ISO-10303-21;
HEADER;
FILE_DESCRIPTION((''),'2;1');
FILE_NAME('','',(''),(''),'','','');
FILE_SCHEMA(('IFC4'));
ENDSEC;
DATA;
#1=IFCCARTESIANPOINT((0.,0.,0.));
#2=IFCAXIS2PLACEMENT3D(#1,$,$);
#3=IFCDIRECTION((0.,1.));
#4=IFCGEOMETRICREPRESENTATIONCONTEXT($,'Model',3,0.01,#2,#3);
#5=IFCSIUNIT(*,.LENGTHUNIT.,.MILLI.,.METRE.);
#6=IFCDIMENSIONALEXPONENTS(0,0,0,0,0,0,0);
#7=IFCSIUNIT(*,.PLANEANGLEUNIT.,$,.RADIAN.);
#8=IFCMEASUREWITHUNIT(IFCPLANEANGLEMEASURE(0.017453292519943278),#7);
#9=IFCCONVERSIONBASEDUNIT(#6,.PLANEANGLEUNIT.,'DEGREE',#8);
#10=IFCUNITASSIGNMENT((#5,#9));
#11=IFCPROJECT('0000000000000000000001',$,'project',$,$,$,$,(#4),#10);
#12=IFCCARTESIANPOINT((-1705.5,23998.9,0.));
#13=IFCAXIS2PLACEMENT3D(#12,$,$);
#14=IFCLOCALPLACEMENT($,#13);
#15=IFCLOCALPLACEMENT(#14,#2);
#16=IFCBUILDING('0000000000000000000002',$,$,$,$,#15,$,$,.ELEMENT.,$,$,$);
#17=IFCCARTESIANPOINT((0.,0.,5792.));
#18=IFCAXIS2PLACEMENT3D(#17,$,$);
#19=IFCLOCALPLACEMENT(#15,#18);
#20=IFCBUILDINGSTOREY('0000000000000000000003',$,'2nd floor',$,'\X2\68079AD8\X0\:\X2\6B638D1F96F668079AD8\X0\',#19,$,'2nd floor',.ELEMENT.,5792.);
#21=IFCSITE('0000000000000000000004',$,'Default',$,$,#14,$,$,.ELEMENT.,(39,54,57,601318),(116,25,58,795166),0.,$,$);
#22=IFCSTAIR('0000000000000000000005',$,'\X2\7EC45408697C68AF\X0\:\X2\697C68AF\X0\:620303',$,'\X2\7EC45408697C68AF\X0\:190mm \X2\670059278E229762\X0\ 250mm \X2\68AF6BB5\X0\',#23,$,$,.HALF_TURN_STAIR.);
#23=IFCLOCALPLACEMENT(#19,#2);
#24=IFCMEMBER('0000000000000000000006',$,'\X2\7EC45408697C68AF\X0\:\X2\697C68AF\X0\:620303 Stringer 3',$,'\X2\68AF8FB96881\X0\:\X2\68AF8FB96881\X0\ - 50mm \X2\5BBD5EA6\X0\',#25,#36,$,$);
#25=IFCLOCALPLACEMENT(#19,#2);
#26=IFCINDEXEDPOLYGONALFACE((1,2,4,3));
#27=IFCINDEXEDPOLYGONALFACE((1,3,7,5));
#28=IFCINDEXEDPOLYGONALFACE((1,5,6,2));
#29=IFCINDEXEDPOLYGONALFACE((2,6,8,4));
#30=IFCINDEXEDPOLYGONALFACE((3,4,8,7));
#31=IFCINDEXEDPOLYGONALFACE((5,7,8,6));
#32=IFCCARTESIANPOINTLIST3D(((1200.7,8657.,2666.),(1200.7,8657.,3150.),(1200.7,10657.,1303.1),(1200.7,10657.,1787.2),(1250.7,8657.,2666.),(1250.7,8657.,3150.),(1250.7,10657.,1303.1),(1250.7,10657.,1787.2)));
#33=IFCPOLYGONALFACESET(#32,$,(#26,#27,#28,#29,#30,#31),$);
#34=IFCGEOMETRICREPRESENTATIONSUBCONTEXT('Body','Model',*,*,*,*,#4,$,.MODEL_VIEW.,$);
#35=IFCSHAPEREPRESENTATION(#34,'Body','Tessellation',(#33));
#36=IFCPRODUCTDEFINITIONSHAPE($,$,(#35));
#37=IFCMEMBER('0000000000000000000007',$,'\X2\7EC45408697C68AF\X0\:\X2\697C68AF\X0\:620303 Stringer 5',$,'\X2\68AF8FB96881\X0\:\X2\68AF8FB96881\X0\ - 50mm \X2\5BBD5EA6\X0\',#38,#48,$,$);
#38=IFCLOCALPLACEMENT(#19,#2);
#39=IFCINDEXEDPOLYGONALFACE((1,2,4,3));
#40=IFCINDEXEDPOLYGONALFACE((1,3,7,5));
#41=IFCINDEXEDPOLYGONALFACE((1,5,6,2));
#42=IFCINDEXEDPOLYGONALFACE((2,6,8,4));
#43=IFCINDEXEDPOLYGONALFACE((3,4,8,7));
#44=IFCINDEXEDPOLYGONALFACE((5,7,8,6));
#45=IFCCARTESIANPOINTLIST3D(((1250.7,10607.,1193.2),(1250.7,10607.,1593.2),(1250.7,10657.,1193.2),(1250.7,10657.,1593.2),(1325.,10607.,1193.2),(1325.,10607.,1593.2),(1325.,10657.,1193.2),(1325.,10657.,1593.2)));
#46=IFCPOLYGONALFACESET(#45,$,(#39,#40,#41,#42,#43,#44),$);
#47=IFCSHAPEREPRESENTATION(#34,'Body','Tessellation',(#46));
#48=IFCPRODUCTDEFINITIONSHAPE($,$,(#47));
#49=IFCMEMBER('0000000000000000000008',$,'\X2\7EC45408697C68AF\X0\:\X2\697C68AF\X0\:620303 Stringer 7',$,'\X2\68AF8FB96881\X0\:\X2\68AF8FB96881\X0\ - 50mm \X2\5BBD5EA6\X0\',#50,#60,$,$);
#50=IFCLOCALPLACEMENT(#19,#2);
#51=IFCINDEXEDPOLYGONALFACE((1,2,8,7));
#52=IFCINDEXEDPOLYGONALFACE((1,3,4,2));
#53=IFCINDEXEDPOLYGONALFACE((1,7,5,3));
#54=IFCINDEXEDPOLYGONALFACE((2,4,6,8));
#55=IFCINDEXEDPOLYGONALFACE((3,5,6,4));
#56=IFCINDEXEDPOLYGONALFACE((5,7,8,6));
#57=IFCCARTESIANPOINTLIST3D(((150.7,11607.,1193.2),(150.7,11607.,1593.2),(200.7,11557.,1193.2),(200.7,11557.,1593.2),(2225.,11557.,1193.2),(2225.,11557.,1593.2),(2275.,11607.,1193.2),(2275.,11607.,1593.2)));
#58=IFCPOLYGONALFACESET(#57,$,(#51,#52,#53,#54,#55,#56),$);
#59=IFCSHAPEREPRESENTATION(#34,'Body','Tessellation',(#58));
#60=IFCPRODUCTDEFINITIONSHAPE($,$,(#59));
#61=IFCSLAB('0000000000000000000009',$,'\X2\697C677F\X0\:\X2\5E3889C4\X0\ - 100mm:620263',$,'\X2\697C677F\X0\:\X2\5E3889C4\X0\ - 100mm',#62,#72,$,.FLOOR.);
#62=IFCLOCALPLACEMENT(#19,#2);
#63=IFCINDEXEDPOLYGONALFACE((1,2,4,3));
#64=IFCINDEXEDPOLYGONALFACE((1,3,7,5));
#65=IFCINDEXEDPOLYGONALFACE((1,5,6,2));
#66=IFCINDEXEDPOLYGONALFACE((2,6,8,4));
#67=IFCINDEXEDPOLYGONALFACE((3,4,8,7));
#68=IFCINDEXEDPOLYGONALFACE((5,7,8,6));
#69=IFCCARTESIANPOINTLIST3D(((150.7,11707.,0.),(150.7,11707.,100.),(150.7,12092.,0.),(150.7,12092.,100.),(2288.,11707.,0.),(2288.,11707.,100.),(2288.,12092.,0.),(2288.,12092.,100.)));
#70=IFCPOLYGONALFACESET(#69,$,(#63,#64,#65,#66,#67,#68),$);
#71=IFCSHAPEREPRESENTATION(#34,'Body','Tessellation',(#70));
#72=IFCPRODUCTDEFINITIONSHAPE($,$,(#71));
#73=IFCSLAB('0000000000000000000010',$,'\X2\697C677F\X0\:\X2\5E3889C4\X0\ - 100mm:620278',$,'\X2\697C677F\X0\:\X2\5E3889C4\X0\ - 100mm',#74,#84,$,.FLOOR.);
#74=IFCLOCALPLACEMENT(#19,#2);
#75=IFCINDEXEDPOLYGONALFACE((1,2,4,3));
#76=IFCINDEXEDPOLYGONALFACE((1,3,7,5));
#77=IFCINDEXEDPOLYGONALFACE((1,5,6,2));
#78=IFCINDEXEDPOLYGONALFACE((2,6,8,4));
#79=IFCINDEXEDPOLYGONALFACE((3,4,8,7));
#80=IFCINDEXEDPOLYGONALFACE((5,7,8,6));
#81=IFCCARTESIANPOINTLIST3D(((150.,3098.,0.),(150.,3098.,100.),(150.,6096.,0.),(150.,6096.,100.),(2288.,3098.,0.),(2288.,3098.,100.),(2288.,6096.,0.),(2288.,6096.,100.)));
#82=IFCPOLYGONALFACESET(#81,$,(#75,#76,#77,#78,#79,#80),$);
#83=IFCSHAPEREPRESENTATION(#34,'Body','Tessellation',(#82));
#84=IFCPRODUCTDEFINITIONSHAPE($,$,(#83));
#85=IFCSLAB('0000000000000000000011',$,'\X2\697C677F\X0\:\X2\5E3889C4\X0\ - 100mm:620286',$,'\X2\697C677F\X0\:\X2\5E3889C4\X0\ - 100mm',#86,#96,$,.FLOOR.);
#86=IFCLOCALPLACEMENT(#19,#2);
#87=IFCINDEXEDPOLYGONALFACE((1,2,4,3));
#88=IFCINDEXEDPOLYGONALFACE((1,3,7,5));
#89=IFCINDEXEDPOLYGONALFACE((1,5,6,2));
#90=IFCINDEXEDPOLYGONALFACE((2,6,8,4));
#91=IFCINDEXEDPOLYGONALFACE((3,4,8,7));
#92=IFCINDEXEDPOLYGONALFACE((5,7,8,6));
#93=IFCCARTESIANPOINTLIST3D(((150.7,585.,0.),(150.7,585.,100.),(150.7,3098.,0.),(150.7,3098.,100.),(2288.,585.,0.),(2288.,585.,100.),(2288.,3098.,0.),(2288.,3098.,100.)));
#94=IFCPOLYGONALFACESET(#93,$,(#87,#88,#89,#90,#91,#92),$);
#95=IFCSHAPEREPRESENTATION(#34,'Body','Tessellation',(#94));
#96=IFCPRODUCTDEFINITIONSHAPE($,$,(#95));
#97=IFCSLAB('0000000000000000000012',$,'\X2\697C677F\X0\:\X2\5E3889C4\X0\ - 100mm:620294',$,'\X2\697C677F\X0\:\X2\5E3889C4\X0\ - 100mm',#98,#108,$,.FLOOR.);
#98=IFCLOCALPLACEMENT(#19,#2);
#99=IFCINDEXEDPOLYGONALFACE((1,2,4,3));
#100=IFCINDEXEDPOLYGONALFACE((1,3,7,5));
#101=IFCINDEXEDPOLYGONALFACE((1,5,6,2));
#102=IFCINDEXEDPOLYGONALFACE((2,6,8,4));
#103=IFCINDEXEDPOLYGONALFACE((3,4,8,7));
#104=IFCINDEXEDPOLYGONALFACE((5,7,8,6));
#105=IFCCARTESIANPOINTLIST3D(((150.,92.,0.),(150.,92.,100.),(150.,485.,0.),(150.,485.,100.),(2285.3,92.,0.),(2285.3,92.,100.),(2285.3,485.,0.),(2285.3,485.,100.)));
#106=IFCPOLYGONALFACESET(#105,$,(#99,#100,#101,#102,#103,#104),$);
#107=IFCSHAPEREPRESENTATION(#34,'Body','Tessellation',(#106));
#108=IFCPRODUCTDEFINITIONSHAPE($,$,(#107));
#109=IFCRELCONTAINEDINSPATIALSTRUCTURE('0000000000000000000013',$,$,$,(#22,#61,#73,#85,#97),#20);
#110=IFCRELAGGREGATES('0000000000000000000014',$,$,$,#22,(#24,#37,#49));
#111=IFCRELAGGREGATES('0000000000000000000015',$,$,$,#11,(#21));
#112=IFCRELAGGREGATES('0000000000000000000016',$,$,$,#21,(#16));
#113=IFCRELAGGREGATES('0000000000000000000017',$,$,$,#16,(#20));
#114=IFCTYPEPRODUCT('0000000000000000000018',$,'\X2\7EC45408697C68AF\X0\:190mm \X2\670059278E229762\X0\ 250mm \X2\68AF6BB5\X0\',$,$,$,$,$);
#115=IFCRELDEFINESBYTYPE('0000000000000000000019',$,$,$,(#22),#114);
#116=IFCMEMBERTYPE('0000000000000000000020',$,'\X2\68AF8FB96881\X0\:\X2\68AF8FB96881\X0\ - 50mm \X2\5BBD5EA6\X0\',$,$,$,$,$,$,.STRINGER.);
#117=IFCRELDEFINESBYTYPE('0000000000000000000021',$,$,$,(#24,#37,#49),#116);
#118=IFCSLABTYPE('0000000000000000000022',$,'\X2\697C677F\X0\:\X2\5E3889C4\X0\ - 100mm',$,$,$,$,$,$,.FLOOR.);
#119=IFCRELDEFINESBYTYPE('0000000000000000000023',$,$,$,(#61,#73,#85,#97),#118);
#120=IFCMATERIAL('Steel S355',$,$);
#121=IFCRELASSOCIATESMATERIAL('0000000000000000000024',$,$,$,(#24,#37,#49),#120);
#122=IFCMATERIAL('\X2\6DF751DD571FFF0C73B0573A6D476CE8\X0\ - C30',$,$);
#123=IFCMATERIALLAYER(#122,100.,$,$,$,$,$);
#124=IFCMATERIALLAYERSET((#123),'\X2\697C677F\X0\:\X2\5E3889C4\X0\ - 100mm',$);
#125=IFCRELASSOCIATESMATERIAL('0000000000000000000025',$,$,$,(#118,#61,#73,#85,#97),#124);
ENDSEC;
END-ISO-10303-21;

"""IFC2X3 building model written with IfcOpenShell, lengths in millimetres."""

from ifc_helpers import new_model, entity, si_unit, converted_unit, direction, frame, frame_2d, origin, origin_2d_with_axis, place, context, subcontext, project, spatial, polyline, rectangle, outline, extrude, material, layer, layer_set, layer_usage, type_object, element, aggregate, save


model = new_model("IFC2X3")

# Units and contexts
model_context = context("Model", 3, precision=0.01, world=origin(), true_north=direction((0.0, 1.0)))
body_context = subcontext(model_context, "Body", "Model", "MODEL_VIEW")
ifc_project = project(units=[si_unit("LENGTHUNIT", "METRE", prefix="MILLI"), converted_unit("PLANEANGLEUNIT", "DEGREE", entity("IfcPlaneAngleMeasure", 0.017453292519943278), si_unit("PLANEANGLEUNIT", "RADIAN"), dimensions=[0, 0, 0, 0, 0, 0, 0])], contexts=[model_context])

# Site, building, storey
site_placement = place(None, frame((-1705.5, 23998.9, 0.0)))
site = spatial("IfcSite", under=ifc_project, at=site_placement, Name="Default", CompositionType="ELEMENT", RefLatitude=(39, 54, 57, 601318), RefLongitude=(116, 25, 58, 795166), RefElevation=0.0)
building_placement = place(site_placement, origin())
building = spatial("IfcBuilding", under=site, at=building_placement, CompositionType="ELEMENT")
storey_placement = place(building_placement, frame((0.0, 0.0, 5792.0)))
storey = spatial("IfcBuildingStorey", under=building, at=storey_placement, Name="2nd floor", ObjectType="标高:正负零标高", LongName="2nd floor", CompositionType="ELEMENT", Elevation=5792.0)

# Stair, members
type_product = type_object("IfcTypeProduct", Name="组合楼梯:190mm 最大踢面 250mm 梯段")
stair_placement = place(storey_placement, origin())
stair = element("IfcStair", 1, at=stair_placement, inside=storey, type_object=type_product, Name="组合楼梯:楼梯:620303", ObjectType="组合楼梯:190mm 最大踢面 250mm 梯段", ShapeType="HALF_TURN_STAIR")
ifc_material_1 = material(Name="Steel S355")
member_type = type_object("IfcMemberType", Name="梯边梁:梯边梁 - 50mm 宽度", PredefinedType="STRINGER")
member_1_placement = place(stair_placement, origin())
member_1 = element("IfcMember", 2, at=member_1_placement, type_object=member_type, material=ifc_material_1, Name="组合楼梯:楼梯:620303 Stringer 3", ObjectType="梯边梁:梯边梁 - 50mm 宽度", context=body_context, shape_type="SweptSolid", body=[
    extrude(outline(polyline([(-1073.8, -200.0), (1346.4, -200.0), (1073.8, 200.0), (-1346.4, 200.0), (-1073.8, -200.0)])), frame((1200.7, 9657.0, 2226.6), z_axis=(1.0, 0.0, 0.0), x_axis=(0.0, -0.826384, 0.563108)), (0.0, 0.0, 1.0), 50.0),
])
member_2_placement = place(stair_placement, origin())
member_2 = element("IfcMember", 3, at=member_2_placement, type_object=member_type, material=ifc_material_1, Name="组合楼梯:楼梯:620303 Stringer 5", ObjectType="梯边梁:梯边梁 - 50mm 宽度", context=body_context, shape_type="SweptSolid", body=[
    extrude(rectangle(XDim=74.3, YDim=50.0, at=frame_2d((0.0, 0.0), x_axis=(1.0, 0.0))), frame((1287.9, 10632.0, 1193.2)), (0.0, 0.0, 1.0), 400.0),
])
member_3_placement = place(stair_placement, origin())
member_3 = element("IfcMember", 4, at=member_3_placement, type_object=member_type, material=ifc_material_1, Name="组合楼梯:楼梯:620303 Stringer 7", ObjectType="梯边梁:梯边梁 - 50mm 宽度", context=body_context, shape_type="SweptSolid", body=[
    extrude(outline(polyline([(-1062.2, -25.0), (1062.2, -25.0), (1012.2, 25.0), (-1012.2, 25.0), (-1062.2, -25.0)])), frame((1212.8, 11582.0, 1193.2), z_axis=(0.0, 0.0, 1.0), x_axis=(-1.0, 0.0, 0.0)), (0.0, 0.0, 1.0), 400.0),
])

# Slabs
ifc_material_2 = material(Name="混凝土，现场浇注 - C30")
ifc_layer_1 = layer(ifc_material_2, 100.0)
ifc_layer_set_1 = layer_set([ifc_layer_1], Name="楼板:常规 - 100mm")
ifc_layer_usage_1 = layer_usage(ifc_layer_set_1, "AXIS3", "POSITIVE", 0.0)
slab_type_1 = type_object("IfcSlabType", Name="楼板:常规 - 100mm", PredefinedType="FLOOR", material=ifc_layer_set_1)
slab_1_placement = place(storey_placement, origin())
element("IfcSlab", 5, at=slab_1_placement, inside=storey, type_object=slab_type_1, material=ifc_layer_usage_1, Name="楼板:常规 - 100mm:620263", ObjectType="楼板:常规 - 100mm", PredefinedType="FLOOR", context=body_context, shape_type="SweptSolid", body=[
    extrude(rectangle(XDim=385.0, YDim=2137.3, at=origin_2d_with_axis()), frame((1219.3, 11899.5, 100.0), z_axis=(0.0, 0.0, -1.0), x_axis=(0.0, 1.0, 0.0)), (0.0, 0.0, 1.0), 100.0),
])
ifc_layer_usage_2 = layer_usage(ifc_layer_set_1, "AXIS3", "POSITIVE", 0.0)
slab_2_placement = place(storey_placement, origin())
element("IfcSlab", 6, at=slab_2_placement, inside=storey, type_object=slab_type_1, material=ifc_layer_usage_2, Name="楼板:常规 - 100mm:620278", ObjectType="楼板:常规 - 100mm", PredefinedType="FLOOR", context=body_context, shape_type="SweptSolid", body=[
    extrude(rectangle(XDim=2998.0, YDim=2138.0, at=frame_2d((0.0, 0.0), x_axis=(1.0, 0.0))), frame((1219.0, 4597.0, 100.0), z_axis=(0.0, 0.0, -1.0), x_axis=(0.0, 1.0, 0.0)), (0.0, 0.0, 1.0), 100.0),
])
ifc_layer_usage_3 = layer_usage(ifc_layer_set_1, "AXIS3", "POSITIVE", 0.0)
slab_3_placement = place(storey_placement, origin())
element("IfcSlab", 7, at=slab_3_placement, inside=storey, type_object=slab_type_1, material=ifc_layer_usage_3, Name="楼板:常规 - 100mm:620286", ObjectType="楼板:常规 - 100mm", PredefinedType="FLOOR", context=body_context, shape_type="SweptSolid", body=[
    extrude(rectangle(XDim=2513.0, YDim=2137.3, at=frame_2d((0.0, 0.0), x_axis=(1.0, 0.0))), frame((1219.3, 1841.5, 100.0), z_axis=(0.0, 0.0, -1.0), x_axis=(0.0, 1.0, 0.0)), (0.0, 0.0, 1.0), 100.0),
])
ifc_layer_usage_4 = layer_usage(ifc_layer_set_1, "AXIS3", "POSITIVE", 0.0)
slab_4_placement = place(storey_placement, origin())
element("IfcSlab", 8, at=slab_4_placement, inside=storey, type_object=slab_type_1, material=ifc_layer_usage_4, Name="楼板:常规 - 100mm:620294", ObjectType="楼板:常规 - 100mm", PredefinedType="FLOOR", context=body_context, shape_type="SweptSolid", body=[
    extrude(rectangle(XDim=393.0, YDim=2135.3, at=frame_2d((0.0, 0.0), x_axis=(1.0, 0.0))), frame((1217.7, 288.5, 100.0), z_axis=(0.0, 0.0, -1.0), x_axis=(0.0, 1.0, 0.0)), (0.0, 0.0, 1.0), 100.0),
])

aggregate(stair, [member_1, member_2, member_3])

save(model, "model.ifc")
